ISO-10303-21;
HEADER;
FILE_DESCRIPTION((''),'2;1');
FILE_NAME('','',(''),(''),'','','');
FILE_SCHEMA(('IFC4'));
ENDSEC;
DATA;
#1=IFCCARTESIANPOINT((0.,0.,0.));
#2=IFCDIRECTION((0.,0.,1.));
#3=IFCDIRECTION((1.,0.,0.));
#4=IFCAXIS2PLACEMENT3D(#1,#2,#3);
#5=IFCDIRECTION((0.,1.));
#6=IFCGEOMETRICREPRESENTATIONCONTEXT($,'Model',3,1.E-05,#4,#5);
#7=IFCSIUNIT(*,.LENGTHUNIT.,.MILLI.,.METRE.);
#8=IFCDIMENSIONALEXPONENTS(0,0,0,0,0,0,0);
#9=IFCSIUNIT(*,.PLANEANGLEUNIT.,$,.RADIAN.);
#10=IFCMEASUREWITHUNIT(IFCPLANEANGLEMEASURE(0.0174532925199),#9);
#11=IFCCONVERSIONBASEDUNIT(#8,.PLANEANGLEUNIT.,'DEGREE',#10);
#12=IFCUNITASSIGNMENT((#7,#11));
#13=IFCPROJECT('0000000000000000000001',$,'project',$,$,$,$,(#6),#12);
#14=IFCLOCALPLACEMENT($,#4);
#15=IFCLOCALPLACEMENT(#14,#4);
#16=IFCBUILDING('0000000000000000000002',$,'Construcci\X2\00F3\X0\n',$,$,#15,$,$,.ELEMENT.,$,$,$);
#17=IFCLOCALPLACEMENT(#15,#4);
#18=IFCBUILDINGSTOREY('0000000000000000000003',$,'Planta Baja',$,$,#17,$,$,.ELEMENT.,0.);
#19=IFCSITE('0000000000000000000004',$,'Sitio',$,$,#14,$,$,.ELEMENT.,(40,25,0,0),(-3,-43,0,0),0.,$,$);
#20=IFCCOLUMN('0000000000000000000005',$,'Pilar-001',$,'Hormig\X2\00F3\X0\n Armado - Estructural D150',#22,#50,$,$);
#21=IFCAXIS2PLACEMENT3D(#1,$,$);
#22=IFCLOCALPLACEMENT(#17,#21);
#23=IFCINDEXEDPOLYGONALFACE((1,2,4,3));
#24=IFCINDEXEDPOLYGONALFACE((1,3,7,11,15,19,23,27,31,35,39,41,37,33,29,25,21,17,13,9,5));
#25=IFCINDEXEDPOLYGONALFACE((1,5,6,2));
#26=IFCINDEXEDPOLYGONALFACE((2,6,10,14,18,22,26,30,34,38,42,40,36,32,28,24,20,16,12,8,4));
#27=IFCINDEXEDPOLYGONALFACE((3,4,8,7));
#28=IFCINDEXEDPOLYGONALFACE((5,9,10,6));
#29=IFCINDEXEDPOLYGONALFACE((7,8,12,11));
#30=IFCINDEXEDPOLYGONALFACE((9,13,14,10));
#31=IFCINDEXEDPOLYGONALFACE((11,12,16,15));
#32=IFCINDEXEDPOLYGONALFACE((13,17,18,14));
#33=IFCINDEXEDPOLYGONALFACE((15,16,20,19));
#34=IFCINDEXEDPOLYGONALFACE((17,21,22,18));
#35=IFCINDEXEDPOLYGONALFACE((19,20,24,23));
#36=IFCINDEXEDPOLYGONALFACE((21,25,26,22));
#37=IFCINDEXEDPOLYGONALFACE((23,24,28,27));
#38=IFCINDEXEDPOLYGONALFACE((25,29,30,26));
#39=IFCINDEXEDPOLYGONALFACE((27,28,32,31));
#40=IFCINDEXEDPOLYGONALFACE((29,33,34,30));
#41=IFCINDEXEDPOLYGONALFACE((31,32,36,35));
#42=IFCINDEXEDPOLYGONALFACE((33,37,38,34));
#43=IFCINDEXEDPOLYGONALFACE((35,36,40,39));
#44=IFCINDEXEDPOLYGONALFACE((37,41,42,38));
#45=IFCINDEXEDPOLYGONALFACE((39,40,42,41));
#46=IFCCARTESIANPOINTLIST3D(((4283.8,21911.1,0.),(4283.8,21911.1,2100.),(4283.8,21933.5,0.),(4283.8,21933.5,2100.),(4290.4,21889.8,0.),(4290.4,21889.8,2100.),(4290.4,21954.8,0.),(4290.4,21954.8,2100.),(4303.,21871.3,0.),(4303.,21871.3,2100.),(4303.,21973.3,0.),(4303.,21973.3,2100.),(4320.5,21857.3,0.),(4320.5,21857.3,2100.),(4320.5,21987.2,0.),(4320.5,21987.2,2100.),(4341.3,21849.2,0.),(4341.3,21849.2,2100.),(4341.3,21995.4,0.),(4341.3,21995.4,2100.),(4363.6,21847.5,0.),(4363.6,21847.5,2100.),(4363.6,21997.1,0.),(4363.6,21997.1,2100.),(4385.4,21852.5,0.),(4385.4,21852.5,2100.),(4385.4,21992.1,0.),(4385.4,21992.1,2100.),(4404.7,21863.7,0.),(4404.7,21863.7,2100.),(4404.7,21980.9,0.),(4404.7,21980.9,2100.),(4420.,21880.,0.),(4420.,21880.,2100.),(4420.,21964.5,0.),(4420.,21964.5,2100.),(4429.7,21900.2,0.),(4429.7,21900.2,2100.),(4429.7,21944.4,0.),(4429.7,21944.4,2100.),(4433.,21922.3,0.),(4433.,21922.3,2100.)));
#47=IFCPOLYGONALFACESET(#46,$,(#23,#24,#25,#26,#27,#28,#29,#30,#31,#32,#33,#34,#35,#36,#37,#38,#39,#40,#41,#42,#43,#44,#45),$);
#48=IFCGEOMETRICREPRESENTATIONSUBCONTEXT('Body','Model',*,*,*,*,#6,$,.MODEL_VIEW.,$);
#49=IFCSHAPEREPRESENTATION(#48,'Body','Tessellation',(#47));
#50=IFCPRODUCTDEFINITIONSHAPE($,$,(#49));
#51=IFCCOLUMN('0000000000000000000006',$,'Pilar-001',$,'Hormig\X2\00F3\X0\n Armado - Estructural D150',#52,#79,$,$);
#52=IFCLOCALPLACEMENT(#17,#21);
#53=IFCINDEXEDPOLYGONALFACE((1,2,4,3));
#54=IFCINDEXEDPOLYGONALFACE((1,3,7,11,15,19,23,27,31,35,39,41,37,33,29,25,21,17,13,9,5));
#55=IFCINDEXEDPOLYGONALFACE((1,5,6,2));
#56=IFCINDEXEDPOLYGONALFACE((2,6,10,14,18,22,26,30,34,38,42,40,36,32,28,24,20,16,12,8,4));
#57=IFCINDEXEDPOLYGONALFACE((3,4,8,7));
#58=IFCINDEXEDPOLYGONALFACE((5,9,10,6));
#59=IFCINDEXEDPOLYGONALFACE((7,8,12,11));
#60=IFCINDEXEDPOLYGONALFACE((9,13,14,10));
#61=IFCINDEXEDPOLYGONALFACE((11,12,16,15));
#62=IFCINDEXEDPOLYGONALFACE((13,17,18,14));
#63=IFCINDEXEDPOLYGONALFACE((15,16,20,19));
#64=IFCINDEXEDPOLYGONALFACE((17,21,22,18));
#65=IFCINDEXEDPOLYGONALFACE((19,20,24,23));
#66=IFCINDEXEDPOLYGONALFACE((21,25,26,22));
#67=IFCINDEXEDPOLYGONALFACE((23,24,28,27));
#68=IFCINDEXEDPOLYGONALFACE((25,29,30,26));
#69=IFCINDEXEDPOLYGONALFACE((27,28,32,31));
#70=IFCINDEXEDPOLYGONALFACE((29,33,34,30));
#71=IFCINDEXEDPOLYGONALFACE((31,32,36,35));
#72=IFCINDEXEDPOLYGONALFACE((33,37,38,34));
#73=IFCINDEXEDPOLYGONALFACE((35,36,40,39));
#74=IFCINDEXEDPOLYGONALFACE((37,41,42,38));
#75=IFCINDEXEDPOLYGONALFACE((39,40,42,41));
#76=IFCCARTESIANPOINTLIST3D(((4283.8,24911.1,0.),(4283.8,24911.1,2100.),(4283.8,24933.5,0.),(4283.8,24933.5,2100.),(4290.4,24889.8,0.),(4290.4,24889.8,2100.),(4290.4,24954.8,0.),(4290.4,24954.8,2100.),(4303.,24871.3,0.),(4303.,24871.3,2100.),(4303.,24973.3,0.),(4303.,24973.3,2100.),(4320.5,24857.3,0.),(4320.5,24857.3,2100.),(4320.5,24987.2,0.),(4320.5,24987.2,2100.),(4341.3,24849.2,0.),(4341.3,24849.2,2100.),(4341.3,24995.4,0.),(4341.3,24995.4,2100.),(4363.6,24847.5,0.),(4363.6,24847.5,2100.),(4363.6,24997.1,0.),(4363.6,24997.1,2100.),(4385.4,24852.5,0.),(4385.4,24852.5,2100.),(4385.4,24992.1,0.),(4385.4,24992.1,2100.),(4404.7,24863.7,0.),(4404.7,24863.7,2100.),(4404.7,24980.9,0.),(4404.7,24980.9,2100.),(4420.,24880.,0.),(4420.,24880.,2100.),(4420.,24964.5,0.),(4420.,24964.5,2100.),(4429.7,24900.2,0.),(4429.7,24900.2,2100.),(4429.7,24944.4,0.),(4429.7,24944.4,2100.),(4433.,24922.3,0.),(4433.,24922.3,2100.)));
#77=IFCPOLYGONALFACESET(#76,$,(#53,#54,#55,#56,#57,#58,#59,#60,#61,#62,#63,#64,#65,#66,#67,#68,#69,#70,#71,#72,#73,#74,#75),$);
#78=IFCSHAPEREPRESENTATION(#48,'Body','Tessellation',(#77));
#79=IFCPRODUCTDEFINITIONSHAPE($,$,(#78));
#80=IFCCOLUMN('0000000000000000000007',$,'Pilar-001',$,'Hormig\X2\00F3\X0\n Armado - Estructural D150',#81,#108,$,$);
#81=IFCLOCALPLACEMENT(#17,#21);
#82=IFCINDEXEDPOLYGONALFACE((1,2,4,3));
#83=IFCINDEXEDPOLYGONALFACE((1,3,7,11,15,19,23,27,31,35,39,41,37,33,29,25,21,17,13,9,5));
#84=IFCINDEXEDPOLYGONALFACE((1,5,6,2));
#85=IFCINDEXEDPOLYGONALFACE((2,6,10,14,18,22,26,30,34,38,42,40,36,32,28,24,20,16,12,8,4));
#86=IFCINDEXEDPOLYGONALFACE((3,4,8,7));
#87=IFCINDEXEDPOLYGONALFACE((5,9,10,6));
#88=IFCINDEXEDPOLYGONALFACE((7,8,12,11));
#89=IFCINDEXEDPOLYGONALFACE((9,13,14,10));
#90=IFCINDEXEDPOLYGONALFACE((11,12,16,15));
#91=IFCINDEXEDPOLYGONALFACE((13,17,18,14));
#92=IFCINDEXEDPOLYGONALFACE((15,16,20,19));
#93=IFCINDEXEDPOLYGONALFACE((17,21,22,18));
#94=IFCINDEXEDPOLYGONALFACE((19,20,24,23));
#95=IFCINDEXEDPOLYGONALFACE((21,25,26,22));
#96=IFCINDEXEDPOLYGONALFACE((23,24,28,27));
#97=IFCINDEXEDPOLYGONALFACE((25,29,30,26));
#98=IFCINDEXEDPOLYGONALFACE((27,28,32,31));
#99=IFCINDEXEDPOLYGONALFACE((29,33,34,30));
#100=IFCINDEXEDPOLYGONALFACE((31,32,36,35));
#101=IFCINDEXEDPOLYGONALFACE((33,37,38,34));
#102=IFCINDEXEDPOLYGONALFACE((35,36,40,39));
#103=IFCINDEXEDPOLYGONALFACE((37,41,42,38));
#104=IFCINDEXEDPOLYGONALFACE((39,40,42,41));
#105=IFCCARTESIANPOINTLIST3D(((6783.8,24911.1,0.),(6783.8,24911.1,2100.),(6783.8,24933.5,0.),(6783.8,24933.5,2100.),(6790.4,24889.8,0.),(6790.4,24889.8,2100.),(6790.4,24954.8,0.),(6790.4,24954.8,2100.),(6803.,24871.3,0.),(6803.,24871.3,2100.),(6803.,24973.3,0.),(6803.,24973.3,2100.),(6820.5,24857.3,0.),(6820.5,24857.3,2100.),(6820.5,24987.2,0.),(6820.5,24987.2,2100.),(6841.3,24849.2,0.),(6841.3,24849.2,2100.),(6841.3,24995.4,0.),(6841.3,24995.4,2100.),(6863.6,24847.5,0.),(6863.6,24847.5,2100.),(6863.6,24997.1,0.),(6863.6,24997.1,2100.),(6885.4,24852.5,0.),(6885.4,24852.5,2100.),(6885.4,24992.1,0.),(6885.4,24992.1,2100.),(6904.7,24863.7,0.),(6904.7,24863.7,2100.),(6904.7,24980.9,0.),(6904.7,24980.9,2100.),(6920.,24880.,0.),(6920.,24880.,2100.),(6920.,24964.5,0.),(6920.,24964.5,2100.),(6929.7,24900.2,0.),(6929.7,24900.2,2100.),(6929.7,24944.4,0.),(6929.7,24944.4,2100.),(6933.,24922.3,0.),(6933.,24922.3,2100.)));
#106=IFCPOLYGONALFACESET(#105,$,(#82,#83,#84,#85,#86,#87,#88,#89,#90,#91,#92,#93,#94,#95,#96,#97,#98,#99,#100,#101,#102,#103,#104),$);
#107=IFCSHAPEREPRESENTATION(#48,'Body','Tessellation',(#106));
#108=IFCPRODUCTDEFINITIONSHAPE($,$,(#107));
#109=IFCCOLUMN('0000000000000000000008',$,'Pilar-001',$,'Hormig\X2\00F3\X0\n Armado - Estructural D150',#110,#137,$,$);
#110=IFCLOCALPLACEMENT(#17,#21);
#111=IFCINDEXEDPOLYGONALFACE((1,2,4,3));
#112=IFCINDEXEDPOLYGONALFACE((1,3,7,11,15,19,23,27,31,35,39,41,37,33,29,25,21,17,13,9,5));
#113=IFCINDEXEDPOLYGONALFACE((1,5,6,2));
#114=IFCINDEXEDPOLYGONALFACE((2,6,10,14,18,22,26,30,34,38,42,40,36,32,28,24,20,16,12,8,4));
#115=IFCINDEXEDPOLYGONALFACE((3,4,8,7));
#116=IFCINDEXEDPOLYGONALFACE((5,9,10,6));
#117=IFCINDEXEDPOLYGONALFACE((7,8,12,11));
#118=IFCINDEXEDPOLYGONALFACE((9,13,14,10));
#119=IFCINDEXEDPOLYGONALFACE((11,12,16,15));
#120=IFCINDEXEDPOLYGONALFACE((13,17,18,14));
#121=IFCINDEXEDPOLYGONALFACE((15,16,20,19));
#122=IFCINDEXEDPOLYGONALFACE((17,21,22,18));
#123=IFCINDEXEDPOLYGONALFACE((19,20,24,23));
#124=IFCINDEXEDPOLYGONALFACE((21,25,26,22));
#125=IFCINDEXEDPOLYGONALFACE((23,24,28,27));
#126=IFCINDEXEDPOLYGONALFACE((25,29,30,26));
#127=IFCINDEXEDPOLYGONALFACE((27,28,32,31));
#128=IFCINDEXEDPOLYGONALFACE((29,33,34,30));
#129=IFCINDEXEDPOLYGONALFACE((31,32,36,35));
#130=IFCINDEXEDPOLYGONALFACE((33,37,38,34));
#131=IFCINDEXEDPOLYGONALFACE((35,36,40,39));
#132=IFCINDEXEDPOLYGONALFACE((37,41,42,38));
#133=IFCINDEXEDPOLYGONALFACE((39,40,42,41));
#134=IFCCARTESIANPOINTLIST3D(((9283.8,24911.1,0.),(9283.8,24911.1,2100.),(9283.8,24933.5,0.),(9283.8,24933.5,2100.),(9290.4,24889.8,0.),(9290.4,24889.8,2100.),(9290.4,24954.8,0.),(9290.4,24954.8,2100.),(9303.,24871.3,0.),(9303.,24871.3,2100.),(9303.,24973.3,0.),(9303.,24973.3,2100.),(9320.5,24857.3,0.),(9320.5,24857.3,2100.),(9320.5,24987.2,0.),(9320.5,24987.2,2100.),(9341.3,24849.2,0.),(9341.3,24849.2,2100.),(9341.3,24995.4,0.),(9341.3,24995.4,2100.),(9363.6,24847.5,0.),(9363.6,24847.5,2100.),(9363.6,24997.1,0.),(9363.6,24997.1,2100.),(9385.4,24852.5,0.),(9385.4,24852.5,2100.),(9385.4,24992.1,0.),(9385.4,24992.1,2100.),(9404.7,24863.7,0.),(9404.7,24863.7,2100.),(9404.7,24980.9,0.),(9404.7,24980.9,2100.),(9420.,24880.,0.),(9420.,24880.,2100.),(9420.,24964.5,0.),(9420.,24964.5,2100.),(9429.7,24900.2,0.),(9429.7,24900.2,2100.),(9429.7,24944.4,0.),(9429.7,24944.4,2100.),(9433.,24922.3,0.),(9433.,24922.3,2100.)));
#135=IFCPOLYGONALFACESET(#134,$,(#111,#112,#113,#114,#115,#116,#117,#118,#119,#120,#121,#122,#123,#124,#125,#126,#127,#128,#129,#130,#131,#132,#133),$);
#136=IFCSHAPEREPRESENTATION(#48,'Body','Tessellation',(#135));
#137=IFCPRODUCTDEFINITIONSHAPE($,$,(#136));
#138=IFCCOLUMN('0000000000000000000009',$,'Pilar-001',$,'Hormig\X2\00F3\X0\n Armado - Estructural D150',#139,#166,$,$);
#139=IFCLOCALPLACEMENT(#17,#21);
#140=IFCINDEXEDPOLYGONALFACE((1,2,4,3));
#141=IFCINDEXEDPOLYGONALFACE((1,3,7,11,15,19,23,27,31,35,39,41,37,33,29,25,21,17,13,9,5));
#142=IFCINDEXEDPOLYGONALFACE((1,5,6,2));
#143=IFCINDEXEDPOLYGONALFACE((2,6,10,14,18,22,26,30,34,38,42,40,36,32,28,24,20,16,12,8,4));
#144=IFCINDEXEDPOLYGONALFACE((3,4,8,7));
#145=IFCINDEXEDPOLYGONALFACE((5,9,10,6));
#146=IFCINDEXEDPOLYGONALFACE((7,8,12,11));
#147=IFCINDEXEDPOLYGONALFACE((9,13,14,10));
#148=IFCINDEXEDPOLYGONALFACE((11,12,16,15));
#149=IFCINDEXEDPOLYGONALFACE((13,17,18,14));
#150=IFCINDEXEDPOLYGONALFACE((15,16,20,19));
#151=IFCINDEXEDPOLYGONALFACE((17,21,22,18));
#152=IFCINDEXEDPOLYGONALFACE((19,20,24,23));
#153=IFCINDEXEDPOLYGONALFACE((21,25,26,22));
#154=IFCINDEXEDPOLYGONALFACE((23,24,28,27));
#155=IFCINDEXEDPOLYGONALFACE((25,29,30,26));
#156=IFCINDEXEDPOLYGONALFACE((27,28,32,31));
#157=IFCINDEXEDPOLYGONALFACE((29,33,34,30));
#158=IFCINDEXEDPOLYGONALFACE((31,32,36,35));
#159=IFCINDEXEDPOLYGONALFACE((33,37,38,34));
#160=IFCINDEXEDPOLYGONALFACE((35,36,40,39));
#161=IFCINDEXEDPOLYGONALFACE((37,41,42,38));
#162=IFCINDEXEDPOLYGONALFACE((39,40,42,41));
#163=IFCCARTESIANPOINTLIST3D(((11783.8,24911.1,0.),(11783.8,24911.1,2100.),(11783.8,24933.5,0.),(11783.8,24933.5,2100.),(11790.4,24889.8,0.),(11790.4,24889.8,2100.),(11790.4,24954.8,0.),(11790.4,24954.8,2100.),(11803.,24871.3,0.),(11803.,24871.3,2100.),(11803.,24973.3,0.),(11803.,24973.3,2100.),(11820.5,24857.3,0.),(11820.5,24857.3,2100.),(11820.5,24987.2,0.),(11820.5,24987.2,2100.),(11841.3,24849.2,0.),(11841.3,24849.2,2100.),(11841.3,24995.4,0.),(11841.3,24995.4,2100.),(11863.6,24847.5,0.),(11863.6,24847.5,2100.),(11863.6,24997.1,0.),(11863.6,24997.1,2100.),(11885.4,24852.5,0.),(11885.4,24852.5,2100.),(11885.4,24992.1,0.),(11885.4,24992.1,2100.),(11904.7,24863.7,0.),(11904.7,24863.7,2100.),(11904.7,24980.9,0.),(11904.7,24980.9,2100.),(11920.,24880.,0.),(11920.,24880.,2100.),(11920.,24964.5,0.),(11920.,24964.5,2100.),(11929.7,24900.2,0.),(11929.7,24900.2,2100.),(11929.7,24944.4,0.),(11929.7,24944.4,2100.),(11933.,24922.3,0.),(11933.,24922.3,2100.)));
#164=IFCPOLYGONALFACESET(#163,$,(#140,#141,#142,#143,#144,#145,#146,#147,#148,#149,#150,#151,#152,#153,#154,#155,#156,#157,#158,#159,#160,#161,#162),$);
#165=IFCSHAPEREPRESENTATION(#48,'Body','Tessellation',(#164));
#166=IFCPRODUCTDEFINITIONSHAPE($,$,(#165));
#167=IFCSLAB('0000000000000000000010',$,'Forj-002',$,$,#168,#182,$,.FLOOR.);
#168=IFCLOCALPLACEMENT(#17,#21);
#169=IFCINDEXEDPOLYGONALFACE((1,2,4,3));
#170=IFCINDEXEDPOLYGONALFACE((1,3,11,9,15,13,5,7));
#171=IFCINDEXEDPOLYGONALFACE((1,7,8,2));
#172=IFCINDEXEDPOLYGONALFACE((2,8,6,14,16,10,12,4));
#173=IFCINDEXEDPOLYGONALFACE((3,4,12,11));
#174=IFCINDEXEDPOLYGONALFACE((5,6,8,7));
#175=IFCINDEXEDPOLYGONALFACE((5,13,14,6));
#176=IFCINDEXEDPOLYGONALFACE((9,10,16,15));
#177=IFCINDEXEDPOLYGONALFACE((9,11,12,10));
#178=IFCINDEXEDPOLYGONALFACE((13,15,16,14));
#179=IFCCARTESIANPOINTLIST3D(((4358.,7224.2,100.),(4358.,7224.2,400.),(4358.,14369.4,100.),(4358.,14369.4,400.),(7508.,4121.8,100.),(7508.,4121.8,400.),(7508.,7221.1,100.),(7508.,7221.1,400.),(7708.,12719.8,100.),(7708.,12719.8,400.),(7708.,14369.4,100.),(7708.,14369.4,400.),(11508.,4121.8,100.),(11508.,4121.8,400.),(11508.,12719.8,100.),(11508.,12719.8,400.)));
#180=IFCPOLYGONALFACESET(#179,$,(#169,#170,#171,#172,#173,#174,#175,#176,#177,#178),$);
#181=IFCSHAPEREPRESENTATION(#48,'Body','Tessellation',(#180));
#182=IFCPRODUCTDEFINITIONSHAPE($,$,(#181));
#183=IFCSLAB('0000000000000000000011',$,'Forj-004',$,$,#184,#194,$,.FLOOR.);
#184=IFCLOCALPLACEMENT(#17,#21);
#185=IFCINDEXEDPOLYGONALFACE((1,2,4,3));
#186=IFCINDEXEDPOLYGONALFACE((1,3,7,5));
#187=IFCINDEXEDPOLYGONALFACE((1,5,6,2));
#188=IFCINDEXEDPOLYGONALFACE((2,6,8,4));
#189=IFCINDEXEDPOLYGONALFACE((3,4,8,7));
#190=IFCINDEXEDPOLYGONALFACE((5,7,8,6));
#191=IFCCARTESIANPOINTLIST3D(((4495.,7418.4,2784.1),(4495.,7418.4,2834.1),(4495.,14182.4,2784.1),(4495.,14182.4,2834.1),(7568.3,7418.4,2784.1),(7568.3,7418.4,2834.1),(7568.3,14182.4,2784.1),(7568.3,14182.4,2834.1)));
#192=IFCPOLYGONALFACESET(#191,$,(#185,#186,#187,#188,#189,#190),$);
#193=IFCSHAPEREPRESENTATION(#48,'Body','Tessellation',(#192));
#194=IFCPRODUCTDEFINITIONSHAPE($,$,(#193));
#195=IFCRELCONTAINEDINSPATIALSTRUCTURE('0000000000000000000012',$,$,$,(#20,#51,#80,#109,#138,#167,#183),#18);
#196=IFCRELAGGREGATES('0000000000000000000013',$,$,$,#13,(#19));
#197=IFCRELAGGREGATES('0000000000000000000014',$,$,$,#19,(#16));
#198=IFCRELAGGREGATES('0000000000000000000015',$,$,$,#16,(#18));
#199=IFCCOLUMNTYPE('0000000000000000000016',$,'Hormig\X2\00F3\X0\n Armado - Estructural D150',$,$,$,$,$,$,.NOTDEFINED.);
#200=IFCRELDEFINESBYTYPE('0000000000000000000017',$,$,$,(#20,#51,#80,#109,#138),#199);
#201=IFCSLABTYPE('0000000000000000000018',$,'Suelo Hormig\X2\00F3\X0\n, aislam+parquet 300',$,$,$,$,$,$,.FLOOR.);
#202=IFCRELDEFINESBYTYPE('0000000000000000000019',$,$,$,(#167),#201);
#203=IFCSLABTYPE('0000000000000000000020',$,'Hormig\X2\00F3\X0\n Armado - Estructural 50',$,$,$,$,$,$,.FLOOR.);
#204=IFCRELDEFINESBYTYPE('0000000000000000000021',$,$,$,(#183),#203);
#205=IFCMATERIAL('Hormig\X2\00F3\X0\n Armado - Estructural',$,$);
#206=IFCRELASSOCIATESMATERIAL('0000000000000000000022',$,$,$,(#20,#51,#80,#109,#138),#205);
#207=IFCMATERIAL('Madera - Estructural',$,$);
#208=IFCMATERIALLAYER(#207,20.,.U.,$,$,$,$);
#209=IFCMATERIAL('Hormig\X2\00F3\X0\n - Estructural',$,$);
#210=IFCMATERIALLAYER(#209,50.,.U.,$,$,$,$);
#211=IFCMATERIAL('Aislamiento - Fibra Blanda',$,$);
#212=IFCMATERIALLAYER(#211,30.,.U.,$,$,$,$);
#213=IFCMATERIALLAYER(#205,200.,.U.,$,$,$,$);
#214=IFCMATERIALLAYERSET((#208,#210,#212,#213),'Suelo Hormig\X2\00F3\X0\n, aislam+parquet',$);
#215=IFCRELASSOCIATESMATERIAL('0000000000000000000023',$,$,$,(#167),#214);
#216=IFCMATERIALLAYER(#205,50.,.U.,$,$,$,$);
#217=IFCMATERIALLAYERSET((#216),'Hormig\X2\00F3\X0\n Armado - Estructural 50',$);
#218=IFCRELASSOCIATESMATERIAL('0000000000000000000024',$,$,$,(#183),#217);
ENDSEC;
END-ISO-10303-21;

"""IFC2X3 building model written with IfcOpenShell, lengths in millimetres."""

from ifc_helpers import new_model, entity, si_unit, converted_unit, direction, frame, origin_with_axes, origin_2d_with_axis, place, context, subcontext, project, spatial, polyline, circle, outline, extrude, material, layer, layer_set, layer_usage, type_object, element, save


model = new_model("IFC2X3")

# Units and contexts
model_context = context("Model", 3, precision=1e-05, world=origin_with_axes(), true_north=direction((0.0, 1.0)))
body_context = subcontext(model_context, "Body", "Model", "MODEL_VIEW")
ifc_project = project(units=[si_unit("LENGTHUNIT", "METRE", prefix="MILLI"), converted_unit("PLANEANGLEUNIT", "DEGREE", entity("IfcPlaneAngleMeasure", 0.0174532925199), si_unit("PLANEANGLEUNIT", "RADIAN"), dimensions=[0, 0, 0, 0, 0, 0, 0])], contexts=[model_context])

# Site, building, storey
site_placement = place(None, origin_with_axes())
site = spatial("IfcSite", under=ifc_project, at=site_placement, Name="Sitio", CompositionType="ELEMENT", RefLatitude=(40, 25, 0, 0), RefLongitude=(-3, -43, 0, 0), RefElevation=0.0)
building_placement = place(site_placement, origin_with_axes())
building = spatial("IfcBuilding", under=site, at=building_placement, Name="Construcción", CompositionType="ELEMENT")
storey_placement = place(building_placement, origin_with_axes())
storey = spatial("IfcBuildingStorey", under=building, at=storey_placement, Name="Planta Baja", CompositionType="ELEMENT", Elevation=0.0)

# Columns
ifc_material_1 = material(Name="Hormigón Armado - Estructural")
column_type = type_object("IfcColumnType", Name="Hormigón Armado - Estructural D150", PredefinedType="NOTDEFINED")
for number, where, z_axis, x_axis, name in (
    (1, (4358.0, 21922.3, 0.0), (0.0, 0.0, 1.0), (1.0, 0.0, 0.0), "Pilar-001"),
    (2, (4358.0, 24922.3, 0.0), (0.0, 0.0, 1.0), (1.0, 0.0, 0.0), "Pilar-001"),
    (3, (6858.0, 24922.3, 0.0), (0.0, 0.0, 1.0), (1.0, 0.0, 0.0), "Pilar-001"),
    (4, (9358.0, 24922.3, 0.0), (0.0, 0.0, 1.0), (1.0, 0.0, 0.0), "Pilar-001"),
    (5, (11858.0, 24922.3, 0.0), (0.0, 0.0, 1.0), (1.0, 0.0, 0.0), "Pilar-001"),
):
    element("IfcColumn", number, at=place(storey_placement, frame(where, z_axis=z_axis, x_axis=x_axis)), inside=storey, type_object=column_type, material=ifc_material_1, Name=name, ObjectType="Hormigón Armado - Estructural D150", context=body_context, shape_type="SweptSolid", body=[
        extrude(circle(Radius=75.0, at=origin_2d_with_axis()), origin_with_axes(), (0.0, 0.0, 1.0), 2100.0),
    ])

# Slabs
ifc_material_2 = material(Name="Madera - Estructural")
ifc_layer_1 = layer(ifc_material_2, 20.0, ventilated="UNKNOWN")
ifc_material_3 = material(Name="Hormigón - Estructural")
ifc_layer_2 = layer(ifc_material_3, 50.0, ventilated="UNKNOWN")
ifc_material_4 = material(Name="Aislamiento - Fibra Blanda")
ifc_layer_3 = layer(ifc_material_4, 30.0, ventilated="UNKNOWN")
ifc_layer_4 = layer(ifc_material_1, 200.0, ventilated="UNKNOWN")
ifc_layer_set_1 = layer_set([ifc_layer_1, ifc_layer_2, ifc_layer_3, ifc_layer_4], Name="Suelo Hormigón, aislam+parquet")
ifc_layer_usage_1 = layer_usage(ifc_layer_set_1, "AXIS3", "NEGATIVE", 300.0)
slab_type_1 = type_object("IfcSlabType", Name="Suelo Hormigón, aislam+parquet 300", PredefinedType="FLOOR")
slab_1_placement = place(storey_placement, frame((4358.0, 14369.4, 400.0), z_axis=(0.0, 0.0, 1.0), x_axis=(1.0, 0.0, 0.0)))
element("IfcSlab", 6, at=slab_1_placement, inside=storey, type_object=slab_type_1, material=ifc_layer_usage_1, Name="Forj-002", PredefinedType="FLOOR", context=body_context, shape_type="SweptSolid", body=[
    extrude(outline(polyline([(0.0, 0.0), (0.0, -7145.2), (3150.0, -7148.3), (3150.0, -10247.6), (7150.0, -10247.6), (7150.0, -1649.6), (3350.0, -1649.6), (3350.0, 0.0), (0.0, 0.0)])), frame((0.0, 0.0, -300.0), z_axis=(0.0, 0.0, 1.0), x_axis=(1.0, 0.0, 0.0)), (0.0, 0.0, 1.0), 300.0),
])
ifc_layer_5 = layer(ifc_material_1, 50.0, ventilated="UNKNOWN")
ifc_layer_set_2 = layer_set([ifc_layer_5], Name="Hormigón Armado - Estructural 50")
ifc_layer_usage_2 = layer_usage(ifc_layer_set_2, "AXIS3", "NEGATIVE", 50.0)
slab_type_2 = type_object("IfcSlabType", Name="Hormigón Armado - Estructural 50", PredefinedType="FLOOR")
slab_2_placement = place(storey_placement, frame((4495.0, 14182.4, 2834.1), z_axis=(0.0, 0.0, 1.0), x_axis=(1.0, 0.0, 0.0)))
element("IfcSlab", 7, at=slab_2_placement, inside=storey, type_object=slab_type_2, material=ifc_layer_usage_2, Name="Forj-004", PredefinedType="FLOOR", context=body_context, shape_type="SweptSolid", body=[
    extrude(outline(polyline([(0.0, 0.0), (0.0, -6764.0), (3073.3, -6764.0), (3073.3, 0.0), (0.0, 0.0)])), frame((0.0, 0.0, -50.0), z_axis=(0.0, 0.0, 1.0), x_axis=(1.0, 0.0, 0.0)), (0.0, 0.0, 1.0), 50.0),
])

save(model, "model.ifc")
